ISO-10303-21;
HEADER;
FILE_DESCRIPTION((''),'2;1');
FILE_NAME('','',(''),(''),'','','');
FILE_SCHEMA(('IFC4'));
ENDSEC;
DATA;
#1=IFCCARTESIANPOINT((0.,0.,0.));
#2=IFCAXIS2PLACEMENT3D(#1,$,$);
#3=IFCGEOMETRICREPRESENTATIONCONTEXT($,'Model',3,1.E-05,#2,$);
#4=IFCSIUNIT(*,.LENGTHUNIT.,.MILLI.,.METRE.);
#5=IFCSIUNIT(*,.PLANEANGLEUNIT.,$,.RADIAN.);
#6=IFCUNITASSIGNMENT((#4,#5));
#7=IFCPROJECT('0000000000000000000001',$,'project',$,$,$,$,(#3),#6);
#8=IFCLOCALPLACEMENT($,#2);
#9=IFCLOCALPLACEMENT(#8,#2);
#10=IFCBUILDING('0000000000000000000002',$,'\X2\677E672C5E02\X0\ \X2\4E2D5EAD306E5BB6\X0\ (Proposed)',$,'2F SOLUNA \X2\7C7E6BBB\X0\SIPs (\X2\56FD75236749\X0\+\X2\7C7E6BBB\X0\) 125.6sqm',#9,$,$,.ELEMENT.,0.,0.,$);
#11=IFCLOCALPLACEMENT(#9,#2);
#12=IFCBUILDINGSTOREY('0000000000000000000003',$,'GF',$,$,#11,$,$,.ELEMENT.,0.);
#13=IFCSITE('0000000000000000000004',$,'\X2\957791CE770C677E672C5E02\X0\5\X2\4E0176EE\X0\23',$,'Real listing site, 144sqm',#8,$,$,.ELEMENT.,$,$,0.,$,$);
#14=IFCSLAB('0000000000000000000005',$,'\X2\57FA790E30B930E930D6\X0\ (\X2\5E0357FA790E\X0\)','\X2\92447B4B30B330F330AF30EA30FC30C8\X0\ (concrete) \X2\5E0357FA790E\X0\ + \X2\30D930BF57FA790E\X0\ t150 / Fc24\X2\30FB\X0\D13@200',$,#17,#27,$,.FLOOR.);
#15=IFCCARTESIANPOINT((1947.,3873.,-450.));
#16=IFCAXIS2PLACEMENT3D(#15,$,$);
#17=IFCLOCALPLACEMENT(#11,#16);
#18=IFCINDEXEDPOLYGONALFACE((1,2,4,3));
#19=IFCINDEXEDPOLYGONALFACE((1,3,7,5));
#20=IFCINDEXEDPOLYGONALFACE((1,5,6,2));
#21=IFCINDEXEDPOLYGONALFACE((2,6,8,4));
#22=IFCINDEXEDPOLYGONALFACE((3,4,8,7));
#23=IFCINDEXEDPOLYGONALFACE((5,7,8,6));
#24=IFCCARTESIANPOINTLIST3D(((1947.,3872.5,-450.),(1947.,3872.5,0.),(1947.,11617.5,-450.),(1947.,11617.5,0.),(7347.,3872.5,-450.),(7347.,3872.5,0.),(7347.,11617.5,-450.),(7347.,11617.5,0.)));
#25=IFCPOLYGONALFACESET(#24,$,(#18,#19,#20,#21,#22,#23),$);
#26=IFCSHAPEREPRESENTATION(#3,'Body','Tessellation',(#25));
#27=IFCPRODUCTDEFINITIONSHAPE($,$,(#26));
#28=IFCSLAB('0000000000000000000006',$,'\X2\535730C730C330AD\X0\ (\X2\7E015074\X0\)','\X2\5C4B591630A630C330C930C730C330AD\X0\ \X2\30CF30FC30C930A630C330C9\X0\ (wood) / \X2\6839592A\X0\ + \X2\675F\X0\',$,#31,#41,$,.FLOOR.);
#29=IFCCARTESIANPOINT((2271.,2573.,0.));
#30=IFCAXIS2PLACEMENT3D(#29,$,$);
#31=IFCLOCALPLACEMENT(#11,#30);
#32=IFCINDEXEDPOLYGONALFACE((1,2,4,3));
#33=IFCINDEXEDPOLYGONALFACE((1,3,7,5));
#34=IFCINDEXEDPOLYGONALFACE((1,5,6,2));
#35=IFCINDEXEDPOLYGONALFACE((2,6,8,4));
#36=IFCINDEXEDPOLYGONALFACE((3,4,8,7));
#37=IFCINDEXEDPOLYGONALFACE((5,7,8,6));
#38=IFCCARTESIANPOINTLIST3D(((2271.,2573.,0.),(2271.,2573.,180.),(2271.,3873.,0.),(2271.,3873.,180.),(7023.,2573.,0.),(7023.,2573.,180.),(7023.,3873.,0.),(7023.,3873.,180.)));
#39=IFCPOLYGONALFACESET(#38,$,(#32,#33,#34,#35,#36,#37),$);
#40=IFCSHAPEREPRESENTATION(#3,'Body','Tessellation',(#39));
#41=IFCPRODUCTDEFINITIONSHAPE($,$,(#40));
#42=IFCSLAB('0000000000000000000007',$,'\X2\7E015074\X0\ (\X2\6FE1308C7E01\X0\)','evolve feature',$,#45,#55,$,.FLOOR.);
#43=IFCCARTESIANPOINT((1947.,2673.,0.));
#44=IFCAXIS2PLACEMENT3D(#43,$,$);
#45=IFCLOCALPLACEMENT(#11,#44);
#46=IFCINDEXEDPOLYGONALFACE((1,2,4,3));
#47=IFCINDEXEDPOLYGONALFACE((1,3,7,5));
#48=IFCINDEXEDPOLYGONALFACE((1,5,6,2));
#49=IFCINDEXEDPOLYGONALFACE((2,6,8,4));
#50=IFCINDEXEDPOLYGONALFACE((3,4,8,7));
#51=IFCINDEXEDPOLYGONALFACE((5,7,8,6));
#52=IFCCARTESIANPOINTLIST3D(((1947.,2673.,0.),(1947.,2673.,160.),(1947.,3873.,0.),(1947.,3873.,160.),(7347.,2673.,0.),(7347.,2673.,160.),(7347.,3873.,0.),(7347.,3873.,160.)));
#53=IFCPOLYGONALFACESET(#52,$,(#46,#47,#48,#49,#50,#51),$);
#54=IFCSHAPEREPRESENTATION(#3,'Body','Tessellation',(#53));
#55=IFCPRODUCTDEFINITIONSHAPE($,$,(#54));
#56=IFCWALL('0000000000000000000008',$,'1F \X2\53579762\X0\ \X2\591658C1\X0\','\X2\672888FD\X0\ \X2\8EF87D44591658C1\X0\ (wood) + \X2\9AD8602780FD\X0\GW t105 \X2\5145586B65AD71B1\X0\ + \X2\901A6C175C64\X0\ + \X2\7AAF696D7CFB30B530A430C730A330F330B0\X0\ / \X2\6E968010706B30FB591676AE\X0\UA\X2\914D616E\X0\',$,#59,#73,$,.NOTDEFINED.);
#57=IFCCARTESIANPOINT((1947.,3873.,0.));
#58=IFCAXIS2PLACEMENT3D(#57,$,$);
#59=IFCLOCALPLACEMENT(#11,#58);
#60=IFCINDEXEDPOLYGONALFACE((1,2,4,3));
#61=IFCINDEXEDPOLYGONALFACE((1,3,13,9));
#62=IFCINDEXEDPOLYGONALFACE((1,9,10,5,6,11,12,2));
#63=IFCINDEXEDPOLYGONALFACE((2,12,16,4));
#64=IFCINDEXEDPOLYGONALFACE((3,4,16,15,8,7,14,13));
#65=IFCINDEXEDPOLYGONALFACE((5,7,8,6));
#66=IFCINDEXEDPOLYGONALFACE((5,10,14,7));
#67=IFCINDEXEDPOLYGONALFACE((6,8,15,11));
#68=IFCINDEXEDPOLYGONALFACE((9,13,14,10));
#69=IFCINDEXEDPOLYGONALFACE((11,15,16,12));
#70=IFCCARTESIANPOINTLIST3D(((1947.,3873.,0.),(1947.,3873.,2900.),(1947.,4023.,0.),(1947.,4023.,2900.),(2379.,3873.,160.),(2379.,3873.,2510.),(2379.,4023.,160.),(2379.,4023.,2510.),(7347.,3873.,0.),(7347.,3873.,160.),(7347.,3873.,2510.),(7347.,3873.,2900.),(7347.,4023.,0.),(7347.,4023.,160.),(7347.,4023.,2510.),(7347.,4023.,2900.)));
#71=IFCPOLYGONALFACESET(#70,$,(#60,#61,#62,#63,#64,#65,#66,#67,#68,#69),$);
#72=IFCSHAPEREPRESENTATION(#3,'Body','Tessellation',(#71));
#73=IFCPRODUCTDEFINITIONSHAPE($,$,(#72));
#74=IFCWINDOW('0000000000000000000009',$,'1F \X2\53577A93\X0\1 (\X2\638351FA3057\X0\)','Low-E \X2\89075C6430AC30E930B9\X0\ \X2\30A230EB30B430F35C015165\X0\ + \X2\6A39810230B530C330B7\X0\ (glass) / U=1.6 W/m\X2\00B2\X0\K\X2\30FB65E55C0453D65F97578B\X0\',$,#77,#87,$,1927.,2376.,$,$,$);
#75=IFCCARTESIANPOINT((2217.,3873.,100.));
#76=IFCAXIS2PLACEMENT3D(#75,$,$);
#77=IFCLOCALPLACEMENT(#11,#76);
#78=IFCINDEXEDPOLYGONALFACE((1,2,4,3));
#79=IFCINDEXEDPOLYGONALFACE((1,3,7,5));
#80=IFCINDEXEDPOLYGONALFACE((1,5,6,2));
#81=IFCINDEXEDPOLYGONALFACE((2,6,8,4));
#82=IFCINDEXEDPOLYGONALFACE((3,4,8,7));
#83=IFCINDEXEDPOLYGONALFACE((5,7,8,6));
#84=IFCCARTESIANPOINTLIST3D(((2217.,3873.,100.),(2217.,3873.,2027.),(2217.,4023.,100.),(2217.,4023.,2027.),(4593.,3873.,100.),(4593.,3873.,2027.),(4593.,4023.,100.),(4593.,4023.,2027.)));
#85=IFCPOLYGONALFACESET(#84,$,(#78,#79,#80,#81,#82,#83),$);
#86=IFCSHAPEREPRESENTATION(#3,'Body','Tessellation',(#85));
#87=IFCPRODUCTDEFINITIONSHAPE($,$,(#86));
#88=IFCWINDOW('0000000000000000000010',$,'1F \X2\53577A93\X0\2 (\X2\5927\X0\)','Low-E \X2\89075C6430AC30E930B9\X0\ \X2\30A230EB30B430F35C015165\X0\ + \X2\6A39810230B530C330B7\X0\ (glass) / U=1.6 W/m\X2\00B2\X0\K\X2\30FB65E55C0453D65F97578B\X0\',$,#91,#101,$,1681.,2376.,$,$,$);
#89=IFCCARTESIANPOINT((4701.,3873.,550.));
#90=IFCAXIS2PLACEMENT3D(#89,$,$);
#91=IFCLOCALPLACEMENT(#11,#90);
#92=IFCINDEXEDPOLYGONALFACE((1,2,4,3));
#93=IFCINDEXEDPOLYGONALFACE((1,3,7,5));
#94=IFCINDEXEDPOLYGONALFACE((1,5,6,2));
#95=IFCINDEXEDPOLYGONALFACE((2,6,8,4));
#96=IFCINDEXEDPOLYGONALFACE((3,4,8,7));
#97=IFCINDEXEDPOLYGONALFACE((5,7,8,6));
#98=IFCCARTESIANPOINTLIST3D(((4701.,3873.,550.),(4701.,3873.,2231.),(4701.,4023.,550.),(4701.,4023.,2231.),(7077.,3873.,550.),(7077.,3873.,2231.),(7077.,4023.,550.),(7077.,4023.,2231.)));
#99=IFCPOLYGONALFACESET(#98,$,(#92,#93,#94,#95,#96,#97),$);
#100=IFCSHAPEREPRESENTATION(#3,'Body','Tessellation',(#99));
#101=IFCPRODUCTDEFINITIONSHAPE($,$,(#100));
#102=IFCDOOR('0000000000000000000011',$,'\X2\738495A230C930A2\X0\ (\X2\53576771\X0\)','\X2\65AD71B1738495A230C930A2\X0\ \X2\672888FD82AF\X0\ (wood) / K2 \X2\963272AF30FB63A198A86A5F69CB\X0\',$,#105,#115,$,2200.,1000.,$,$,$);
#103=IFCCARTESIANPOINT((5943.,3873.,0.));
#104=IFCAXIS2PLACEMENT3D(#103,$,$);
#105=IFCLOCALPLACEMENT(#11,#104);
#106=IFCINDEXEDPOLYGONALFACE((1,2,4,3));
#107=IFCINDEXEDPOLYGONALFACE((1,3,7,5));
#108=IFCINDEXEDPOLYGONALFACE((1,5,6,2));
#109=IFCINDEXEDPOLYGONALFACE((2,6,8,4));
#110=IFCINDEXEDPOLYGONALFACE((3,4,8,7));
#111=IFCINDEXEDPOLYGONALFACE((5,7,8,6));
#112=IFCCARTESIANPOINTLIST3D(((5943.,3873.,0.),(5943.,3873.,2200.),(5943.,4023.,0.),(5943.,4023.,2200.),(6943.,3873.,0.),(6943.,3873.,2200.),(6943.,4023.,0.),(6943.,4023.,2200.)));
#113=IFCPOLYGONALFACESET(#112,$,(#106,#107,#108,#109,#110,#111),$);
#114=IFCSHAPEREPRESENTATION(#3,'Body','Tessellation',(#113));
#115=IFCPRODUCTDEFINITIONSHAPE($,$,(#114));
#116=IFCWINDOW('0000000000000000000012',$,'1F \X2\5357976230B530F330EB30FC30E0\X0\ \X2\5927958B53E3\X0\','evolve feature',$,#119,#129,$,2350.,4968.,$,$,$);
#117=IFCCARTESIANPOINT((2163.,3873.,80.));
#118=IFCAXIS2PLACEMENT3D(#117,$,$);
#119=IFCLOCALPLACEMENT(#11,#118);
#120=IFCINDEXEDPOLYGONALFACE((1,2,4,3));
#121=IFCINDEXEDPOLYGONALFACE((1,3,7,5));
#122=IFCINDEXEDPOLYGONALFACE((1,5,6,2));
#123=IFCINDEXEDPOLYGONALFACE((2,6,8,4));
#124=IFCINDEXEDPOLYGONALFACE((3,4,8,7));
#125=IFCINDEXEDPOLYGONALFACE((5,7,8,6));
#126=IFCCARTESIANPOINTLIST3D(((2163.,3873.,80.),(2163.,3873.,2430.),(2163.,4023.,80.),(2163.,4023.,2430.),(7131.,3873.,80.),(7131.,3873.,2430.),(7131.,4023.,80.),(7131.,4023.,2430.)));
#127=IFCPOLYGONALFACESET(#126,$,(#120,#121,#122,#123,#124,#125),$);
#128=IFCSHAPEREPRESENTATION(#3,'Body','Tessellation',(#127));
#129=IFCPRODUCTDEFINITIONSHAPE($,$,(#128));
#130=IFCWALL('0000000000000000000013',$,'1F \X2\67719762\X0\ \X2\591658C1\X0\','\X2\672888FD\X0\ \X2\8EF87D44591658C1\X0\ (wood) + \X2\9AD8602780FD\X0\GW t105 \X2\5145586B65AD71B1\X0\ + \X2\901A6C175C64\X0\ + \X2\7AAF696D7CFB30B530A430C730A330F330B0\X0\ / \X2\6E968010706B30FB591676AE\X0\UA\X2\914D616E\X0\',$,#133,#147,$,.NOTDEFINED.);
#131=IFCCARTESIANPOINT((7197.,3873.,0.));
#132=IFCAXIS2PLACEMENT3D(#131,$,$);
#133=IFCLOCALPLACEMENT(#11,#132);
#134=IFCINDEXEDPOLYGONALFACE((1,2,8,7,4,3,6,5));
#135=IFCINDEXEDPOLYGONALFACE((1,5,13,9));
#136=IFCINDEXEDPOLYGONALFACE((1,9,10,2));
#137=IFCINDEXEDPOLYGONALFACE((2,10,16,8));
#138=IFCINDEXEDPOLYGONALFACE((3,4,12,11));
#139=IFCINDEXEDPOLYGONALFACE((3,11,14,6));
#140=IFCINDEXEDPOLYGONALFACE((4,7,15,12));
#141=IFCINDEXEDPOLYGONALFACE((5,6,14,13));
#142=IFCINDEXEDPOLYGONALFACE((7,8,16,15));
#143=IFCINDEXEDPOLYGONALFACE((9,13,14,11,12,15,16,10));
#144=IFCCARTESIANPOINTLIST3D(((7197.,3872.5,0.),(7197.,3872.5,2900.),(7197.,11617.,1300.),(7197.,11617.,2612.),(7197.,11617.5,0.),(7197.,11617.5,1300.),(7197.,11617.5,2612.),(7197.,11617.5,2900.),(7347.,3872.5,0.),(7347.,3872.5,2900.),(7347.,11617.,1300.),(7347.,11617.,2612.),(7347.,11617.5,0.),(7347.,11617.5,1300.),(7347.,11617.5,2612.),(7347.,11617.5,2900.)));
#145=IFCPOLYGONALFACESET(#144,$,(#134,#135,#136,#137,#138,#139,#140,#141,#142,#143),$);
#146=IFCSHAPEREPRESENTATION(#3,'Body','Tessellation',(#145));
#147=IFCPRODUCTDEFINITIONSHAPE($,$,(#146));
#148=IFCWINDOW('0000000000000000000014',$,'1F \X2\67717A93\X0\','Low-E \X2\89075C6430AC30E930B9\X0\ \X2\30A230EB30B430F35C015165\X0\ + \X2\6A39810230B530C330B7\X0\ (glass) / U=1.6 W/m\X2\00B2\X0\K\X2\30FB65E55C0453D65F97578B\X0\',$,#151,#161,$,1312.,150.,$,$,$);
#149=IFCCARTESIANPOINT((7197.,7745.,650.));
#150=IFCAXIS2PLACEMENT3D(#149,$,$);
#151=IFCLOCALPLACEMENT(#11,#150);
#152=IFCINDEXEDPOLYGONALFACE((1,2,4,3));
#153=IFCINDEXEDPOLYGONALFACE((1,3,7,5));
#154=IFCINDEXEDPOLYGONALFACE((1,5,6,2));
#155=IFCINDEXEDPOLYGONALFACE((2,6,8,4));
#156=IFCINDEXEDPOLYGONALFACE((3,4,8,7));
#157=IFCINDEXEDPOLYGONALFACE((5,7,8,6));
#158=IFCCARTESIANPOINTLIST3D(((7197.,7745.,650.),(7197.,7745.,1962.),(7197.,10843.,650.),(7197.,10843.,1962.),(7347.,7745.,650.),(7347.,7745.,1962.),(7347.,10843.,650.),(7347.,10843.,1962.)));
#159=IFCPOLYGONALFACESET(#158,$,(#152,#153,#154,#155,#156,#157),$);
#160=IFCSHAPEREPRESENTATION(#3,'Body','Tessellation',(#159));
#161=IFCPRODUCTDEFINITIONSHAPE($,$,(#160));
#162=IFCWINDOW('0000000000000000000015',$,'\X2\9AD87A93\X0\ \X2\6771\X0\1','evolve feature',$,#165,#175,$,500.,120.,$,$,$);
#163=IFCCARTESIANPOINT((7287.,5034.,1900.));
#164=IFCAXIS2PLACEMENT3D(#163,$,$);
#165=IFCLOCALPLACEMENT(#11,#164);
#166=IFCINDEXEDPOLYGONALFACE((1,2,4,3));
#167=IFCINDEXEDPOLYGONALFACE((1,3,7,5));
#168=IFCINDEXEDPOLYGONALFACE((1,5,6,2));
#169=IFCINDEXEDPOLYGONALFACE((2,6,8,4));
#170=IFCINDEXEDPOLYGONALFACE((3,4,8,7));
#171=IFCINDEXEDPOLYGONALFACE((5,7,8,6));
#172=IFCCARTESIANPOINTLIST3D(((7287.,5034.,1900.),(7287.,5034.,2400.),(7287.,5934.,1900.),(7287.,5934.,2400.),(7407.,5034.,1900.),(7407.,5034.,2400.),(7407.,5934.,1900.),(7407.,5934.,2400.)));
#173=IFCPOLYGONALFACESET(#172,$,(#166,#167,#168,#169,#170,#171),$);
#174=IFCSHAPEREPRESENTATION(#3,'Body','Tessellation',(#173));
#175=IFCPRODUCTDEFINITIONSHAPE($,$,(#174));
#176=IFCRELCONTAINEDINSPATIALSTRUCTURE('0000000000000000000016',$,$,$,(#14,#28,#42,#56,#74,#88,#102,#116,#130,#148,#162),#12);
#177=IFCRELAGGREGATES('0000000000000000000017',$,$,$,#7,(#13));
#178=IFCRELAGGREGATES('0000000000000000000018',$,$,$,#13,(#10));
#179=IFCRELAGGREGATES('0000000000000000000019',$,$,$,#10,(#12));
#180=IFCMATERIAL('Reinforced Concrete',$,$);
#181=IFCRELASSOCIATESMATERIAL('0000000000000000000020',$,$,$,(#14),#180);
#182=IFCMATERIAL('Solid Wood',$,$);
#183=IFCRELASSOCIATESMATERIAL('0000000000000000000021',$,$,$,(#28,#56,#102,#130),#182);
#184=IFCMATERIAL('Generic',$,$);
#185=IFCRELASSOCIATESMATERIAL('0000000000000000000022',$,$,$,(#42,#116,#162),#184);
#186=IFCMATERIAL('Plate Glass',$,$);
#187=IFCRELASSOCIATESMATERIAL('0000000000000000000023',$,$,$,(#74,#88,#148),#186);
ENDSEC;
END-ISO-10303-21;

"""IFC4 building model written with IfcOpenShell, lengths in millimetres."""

from ifc_helpers import new_model, si_unit, frame, frame_2d, origin, place, context, project, spatial, rectangle, extrude, material, element, fill, save


model = new_model("IFC4")

# Units and contexts
model_context = context("Model", 3, precision=1e-05, world=origin())
ifc_project = project(units=[si_unit("LENGTHUNIT", "METRE", prefix="MILLI"), si_unit("PLANEANGLEUNIT", "RADIAN")], contexts=[model_context])

# Site, building, storey
site_placement = place(None, origin())
site = spatial("IfcSite", under=ifc_project, at=site_placement, Name="長野県松本市5丁目23", ObjectType="Real listing site, 144sqm", CompositionType="ELEMENT", RefElevation=0.0)
building_placement = place(site_placement, origin())
building = spatial("IfcBuilding", under=site, at=building_placement, Name="松本市 中庭の家 (Proposed)", ObjectType="2F SOLUNA 籾殻SIPs (国産杉+籾殻) 125.6sqm", CompositionType="ELEMENT", ElevationOfRefHeight=0.0, ElevationOfTerrain=0.0)
storey_placement = place(building_placement, origin())
storey = spatial("IfcBuildingStorey", under=building, at=storey_placement, Name="GF", CompositionType="ELEMENT", Elevation=0.0)

# Slabs
ifc_material_1 = material(Name="Reinforced Concrete")
slab_1_placement = place(storey_placement, frame((1947.0, 3873.0, -450.0)))
element("IfcSlab", 1, at=slab_1_placement, inside=storey, material=ifc_material_1, Name="基礎スラブ (布基礎)", Description="鉄筋コンクリート (concrete) 布基礎 + ベタ基礎 t150 / Fc24・D13@200", PredefinedType="FLOOR", context=model_context, shape_type="SweptSolid", body=[
    extrude(rectangle(XDim=5400.0, YDim=7745.0, at=frame_2d((2700.0, 3872.0))), frame((1947.0, 3873.0, -450.0)), (0.0, 0.0, 1.0), 450.0),
])
ifc_material_2 = material(Name="Solid Wood")
slab_2_placement = place(storey_placement, frame((2271.0, 2573.0, 0.0)))
element("IfcSlab", 2, at=slab_2_placement, inside=storey, material=ifc_material_2, Name="南デッキ (縁側)", Description="屋外ウッドデッキ ハードウッド (wood) / 根太 + 束", PredefinedType="FLOOR", context=model_context, shape_type="SweptSolid", body=[
    extrude(rectangle(XDim=4752.0, YDim=1300.0, at=frame_2d((2376.0, 650.0))), frame((2271.0, 2573.0, 0.0)), (0.0, 0.0, 1.0), 180.0),
])
ifc_material_3 = material(Name="Generic")
slab_3_placement = place(storey_placement, frame((1947.0, 2673.0, 0.0)))
element("IfcSlab", 3, at=slab_3_placement, inside=storey, material=ifc_material_3, Name="縁側 (濡れ縁)", Description="evolve feature", PredefinedType="FLOOR", context=model_context, shape_type="SweptSolid", body=[
    extrude(rectangle(XDim=5400.0, YDim=1200.0, at=frame_2d((2700.0, 600.0))), frame((1947.0, 2673.0, 0.0)), (0.0, 0.0, 1.0), 160.0),
])

# Wall, openings, windows, door
wall_1_placement = place(storey_placement, frame((1947.0, 3873.0, 0.0)))
wall_1 = element("IfcWall", 4, at=wall_1_placement, inside=storey, material=ifc_material_2, Name="1F 南面 外壁", Description="木製 軸組外壁 (wood) + 高性能GW t105 充填断熱 + 通気層 + 窯業系サイディング / 準耐火・外皮UA配慮", PredefinedType="NOTDEFINED", context=model_context, shape_type="SweptSolid", body=[
    extrude(rectangle(XDim=5400.0, YDim=150.0, at=frame_2d((2700.0, 75.0))), frame((1947.0, 3873.0, 0.0)), (0.0, 0.0, 1.0), 2900.0),
])
opening_1_placement = place(storey_placement, frame((2217.0, 3873.0, 100.0)))
opening_1 = element("IfcOpeningElement", 5, at=opening_1_placement, cuts=wall_1, PredefinedType="NOTDEFINED", context=model_context, shape_type="SweptSolid", body=[
    extrude(rectangle(XDim=2376.0, YDim=150.0, at=frame_2d((1188.0, 75.0))), frame((2217.0, 3873.0, 100.0)), (0.0, 0.0, 1.0), 1927.0),
])
opening_2_placement = place(storey_placement, frame((4701.0, 3873.0, 550.0)))
opening_2 = element("IfcOpeningElement", 6, at=opening_2_placement, cuts=wall_1, PredefinedType="NOTDEFINED", context=model_context, shape_type="SweptSolid", body=[
    extrude(rectangle(XDim=2376.0, YDim=150.0, at=frame_2d((1188.0, 75.0))), frame((4701.0, 3873.0, 550.0)), (0.0, 0.0, 1.0), 1681.0),
])
opening_3_placement = place(storey_placement, frame((5943.0, 3873.0, 0.0)))
opening_3 = element("IfcOpeningElement", 7, at=opening_3_placement, cuts=wall_1, PredefinedType="NOTDEFINED", context=model_context, shape_type="SweptSolid", body=[
    extrude(rectangle(XDim=1000.0, YDim=150.0, at=frame_2d((500.0, 75.0))), frame((5943.0, 3873.0, 0.0)), (0.0, 0.0, 1.0), 2200.0),
])
opening_4_placement = place(storey_placement, frame((2163.0, 3873.0, 80.0)))
opening_4 = element("IfcOpeningElement", 8, at=opening_4_placement, cuts=wall_1, PredefinedType="NOTDEFINED", context=model_context, shape_type="SweptSolid", body=[
    extrude(rectangle(XDim=4968.0, YDim=150.0, at=frame_2d((2484.0, 75.0))), frame((2163.0, 3873.0, 80.0)), (0.0, 0.0, 1.0), 2350.0),
])
ifc_material_4 = material(Name="Plate Glass")
window_1_placement = place(storey_placement, frame((2217.0, 3873.0, 100.0)))
window_1 = element("IfcWindow", 9, at=window_1_placement, inside=storey, material=ifc_material_4, Name="1F 南窓1 (掃出し)", Description="Low-E 複層ガラス アルゴン封入 + 樹脂サッシ (glass) / U=1.6 W/m²K・日射取得型", OverallHeight=1927.0, OverallWidth=2376.0, context=model_context, shape_type="SweptSolid", body=[
    extrude(rectangle(XDim=2376.0, YDim=150.0, at=frame_2d((1188.0, 75.0))), frame((2217.0, 3873.0, 100.0)), (0.0, 0.0, 1.0), 1927.0),
])
fill(opening_1, window_1)
window_2_placement = place(storey_placement, frame((4701.0, 3873.0, 550.0)))
window_2 = element("IfcWindow", 10, at=window_2_placement, inside=storey, material=ifc_material_4, Name="1F 南窓2 (大)", Description="Low-E 複層ガラス アルゴン封入 + 樹脂サッシ (glass) / U=1.6 W/m²K・日射取得型", OverallHeight=1681.0, OverallWidth=2376.0, context=model_context, shape_type="SweptSolid", body=[
    extrude(rectangle(XDim=2376.0, YDim=150.0, at=frame_2d((1188.0, 75.0))), frame((4701.0, 3873.0, 550.0)), (0.0, 0.0, 1.0), 1681.0),
])
fill(opening_2, window_2)
door_placement = place(storey_placement, frame((5943.0, 3873.0, 0.0)))
door = element("IfcDoor", 11, at=door_placement, inside=storey, material=ifc_material_2, Name="玄関ドア (南東)", Description="断熱玄関ドア 木製芯 (wood) / K2 防犯・採風機構", OverallHeight=2200.0, OverallWidth=1000.0, context=model_context, shape_type="SweptSolid", body=[
    extrude(rectangle(XDim=1000.0, YDim=150.0, at=frame_2d((500.0, 75.0))), frame((5943.0, 3873.0, 0.0)), (0.0, 0.0, 1.0), 2200.0),
])
fill(opening_3, door)
window_3_placement = place(storey_placement, frame((2163.0, 3873.0, 80.0)))
window_3 = element("IfcWindow", 12, at=window_3_placement, inside=storey, material=ifc_material_3, Name="1F 南面サンルーム 大開口", Description="evolve feature", OverallHeight=2350.0, OverallWidth=4968.0, context=model_context, shape_type="SweptSolid", body=[
    extrude(rectangle(XDim=4968.0, YDim=150.0, at=frame_2d((2484.0, 75.0))), frame((2163.0, 3873.0, 80.0)), (0.0, 0.0, 1.0), 2350.0),
])
fill(opening_4, window_3)

# Wall, openings, windows
wall_2_placement = place(storey_placement, frame((7197.0, 3873.0, 0.0)))
wall_2 = element("IfcWall", 13, at=wall_2_placement, inside=storey, material=ifc_material_2, Name="1F 東面 外壁", Description="木製 軸組外壁 (wood) + 高性能GW t105 充填断熱 + 通気層 + 窯業系サイディング / 準耐火・外皮UA配慮", PredefinedType="NOTDEFINED", context=model_context, shape_type="SweptSolid", body=[
    extrude(rectangle(XDim=150.0, YDim=7745.0, at=frame_2d((75.0, 3872.0))), frame((7197.0, 3873.0, 0.0)), (0.0, 0.0, 1.0), 2900.0),
])
opening_5_placement = place(storey_placement, frame((7197.0, 7745.0, 650.0)))
opening_5 = element("IfcOpeningElement", 14, at=opening_5_placement, cuts=wall_2, PredefinedType="NOTDEFINED", context=model_context, shape_type="SweptSolid", body=[
    extrude(rectangle(XDim=150.0, YDim=3098.0, at=frame_2d((75.0, 1549.0))), frame((7197.0, 7745.0, 650.0)), (0.0, 0.0, 1.0), 1312.0),
])
opening_6_placement = place(storey_placement, frame((7287.0, 5034.0, 1900.0)))
opening_6 = element("IfcOpeningElement", 15, at=opening_6_placement, cuts=wall_2, PredefinedType="NOTDEFINED", context=model_context, shape_type="SweptSolid", body=[
    extrude(rectangle(XDim=120.0, YDim=900.0, at=frame_2d((60.0, 450.0))), frame((7287.0, 5034.0, 1900.0)), (0.0, 0.0, 1.0), 500.0),
])
window_4_placement = place(storey_placement, frame((7197.0, 7745.0, 650.0)))
window_4 = element("IfcWindow", 16, at=window_4_placement, inside=storey, material=ifc_material_4, Name="1F 東窓", Description="Low-E 複層ガラス アルゴン封入 + 樹脂サッシ (glass) / U=1.6 W/m²K・日射取得型", OverallHeight=1312.0, OverallWidth=150.0, context=model_context, shape_type="SweptSolid", body=[
    extrude(rectangle(XDim=150.0, YDim=3098.0, at=frame_2d((75.0, 1549.0))), frame((7197.0, 7745.0, 650.0)), (0.0, 0.0, 1.0), 1312.0),
])
fill(opening_5, window_4)
window_5_placement = place(storey_placement, frame((7287.0, 5034.0, 1900.0)))
window_5 = element("IfcWindow", 17, at=window_5_placement, inside=storey, material=ifc_material_3, Name="高窓 東1", Description="evolve feature", OverallHeight=500.0, OverallWidth=120.0, context=model_context, shape_type="SweptSolid", body=[
    extrude(rectangle(XDim=120.0, YDim=900.0, at=frame_2d((60.0, 450.0))), frame((7287.0, 5034.0, 1900.0)), (0.0, 0.0, 1.0), 500.0),
])
fill(opening_6, window_5)

save(model, "model.ifc")
